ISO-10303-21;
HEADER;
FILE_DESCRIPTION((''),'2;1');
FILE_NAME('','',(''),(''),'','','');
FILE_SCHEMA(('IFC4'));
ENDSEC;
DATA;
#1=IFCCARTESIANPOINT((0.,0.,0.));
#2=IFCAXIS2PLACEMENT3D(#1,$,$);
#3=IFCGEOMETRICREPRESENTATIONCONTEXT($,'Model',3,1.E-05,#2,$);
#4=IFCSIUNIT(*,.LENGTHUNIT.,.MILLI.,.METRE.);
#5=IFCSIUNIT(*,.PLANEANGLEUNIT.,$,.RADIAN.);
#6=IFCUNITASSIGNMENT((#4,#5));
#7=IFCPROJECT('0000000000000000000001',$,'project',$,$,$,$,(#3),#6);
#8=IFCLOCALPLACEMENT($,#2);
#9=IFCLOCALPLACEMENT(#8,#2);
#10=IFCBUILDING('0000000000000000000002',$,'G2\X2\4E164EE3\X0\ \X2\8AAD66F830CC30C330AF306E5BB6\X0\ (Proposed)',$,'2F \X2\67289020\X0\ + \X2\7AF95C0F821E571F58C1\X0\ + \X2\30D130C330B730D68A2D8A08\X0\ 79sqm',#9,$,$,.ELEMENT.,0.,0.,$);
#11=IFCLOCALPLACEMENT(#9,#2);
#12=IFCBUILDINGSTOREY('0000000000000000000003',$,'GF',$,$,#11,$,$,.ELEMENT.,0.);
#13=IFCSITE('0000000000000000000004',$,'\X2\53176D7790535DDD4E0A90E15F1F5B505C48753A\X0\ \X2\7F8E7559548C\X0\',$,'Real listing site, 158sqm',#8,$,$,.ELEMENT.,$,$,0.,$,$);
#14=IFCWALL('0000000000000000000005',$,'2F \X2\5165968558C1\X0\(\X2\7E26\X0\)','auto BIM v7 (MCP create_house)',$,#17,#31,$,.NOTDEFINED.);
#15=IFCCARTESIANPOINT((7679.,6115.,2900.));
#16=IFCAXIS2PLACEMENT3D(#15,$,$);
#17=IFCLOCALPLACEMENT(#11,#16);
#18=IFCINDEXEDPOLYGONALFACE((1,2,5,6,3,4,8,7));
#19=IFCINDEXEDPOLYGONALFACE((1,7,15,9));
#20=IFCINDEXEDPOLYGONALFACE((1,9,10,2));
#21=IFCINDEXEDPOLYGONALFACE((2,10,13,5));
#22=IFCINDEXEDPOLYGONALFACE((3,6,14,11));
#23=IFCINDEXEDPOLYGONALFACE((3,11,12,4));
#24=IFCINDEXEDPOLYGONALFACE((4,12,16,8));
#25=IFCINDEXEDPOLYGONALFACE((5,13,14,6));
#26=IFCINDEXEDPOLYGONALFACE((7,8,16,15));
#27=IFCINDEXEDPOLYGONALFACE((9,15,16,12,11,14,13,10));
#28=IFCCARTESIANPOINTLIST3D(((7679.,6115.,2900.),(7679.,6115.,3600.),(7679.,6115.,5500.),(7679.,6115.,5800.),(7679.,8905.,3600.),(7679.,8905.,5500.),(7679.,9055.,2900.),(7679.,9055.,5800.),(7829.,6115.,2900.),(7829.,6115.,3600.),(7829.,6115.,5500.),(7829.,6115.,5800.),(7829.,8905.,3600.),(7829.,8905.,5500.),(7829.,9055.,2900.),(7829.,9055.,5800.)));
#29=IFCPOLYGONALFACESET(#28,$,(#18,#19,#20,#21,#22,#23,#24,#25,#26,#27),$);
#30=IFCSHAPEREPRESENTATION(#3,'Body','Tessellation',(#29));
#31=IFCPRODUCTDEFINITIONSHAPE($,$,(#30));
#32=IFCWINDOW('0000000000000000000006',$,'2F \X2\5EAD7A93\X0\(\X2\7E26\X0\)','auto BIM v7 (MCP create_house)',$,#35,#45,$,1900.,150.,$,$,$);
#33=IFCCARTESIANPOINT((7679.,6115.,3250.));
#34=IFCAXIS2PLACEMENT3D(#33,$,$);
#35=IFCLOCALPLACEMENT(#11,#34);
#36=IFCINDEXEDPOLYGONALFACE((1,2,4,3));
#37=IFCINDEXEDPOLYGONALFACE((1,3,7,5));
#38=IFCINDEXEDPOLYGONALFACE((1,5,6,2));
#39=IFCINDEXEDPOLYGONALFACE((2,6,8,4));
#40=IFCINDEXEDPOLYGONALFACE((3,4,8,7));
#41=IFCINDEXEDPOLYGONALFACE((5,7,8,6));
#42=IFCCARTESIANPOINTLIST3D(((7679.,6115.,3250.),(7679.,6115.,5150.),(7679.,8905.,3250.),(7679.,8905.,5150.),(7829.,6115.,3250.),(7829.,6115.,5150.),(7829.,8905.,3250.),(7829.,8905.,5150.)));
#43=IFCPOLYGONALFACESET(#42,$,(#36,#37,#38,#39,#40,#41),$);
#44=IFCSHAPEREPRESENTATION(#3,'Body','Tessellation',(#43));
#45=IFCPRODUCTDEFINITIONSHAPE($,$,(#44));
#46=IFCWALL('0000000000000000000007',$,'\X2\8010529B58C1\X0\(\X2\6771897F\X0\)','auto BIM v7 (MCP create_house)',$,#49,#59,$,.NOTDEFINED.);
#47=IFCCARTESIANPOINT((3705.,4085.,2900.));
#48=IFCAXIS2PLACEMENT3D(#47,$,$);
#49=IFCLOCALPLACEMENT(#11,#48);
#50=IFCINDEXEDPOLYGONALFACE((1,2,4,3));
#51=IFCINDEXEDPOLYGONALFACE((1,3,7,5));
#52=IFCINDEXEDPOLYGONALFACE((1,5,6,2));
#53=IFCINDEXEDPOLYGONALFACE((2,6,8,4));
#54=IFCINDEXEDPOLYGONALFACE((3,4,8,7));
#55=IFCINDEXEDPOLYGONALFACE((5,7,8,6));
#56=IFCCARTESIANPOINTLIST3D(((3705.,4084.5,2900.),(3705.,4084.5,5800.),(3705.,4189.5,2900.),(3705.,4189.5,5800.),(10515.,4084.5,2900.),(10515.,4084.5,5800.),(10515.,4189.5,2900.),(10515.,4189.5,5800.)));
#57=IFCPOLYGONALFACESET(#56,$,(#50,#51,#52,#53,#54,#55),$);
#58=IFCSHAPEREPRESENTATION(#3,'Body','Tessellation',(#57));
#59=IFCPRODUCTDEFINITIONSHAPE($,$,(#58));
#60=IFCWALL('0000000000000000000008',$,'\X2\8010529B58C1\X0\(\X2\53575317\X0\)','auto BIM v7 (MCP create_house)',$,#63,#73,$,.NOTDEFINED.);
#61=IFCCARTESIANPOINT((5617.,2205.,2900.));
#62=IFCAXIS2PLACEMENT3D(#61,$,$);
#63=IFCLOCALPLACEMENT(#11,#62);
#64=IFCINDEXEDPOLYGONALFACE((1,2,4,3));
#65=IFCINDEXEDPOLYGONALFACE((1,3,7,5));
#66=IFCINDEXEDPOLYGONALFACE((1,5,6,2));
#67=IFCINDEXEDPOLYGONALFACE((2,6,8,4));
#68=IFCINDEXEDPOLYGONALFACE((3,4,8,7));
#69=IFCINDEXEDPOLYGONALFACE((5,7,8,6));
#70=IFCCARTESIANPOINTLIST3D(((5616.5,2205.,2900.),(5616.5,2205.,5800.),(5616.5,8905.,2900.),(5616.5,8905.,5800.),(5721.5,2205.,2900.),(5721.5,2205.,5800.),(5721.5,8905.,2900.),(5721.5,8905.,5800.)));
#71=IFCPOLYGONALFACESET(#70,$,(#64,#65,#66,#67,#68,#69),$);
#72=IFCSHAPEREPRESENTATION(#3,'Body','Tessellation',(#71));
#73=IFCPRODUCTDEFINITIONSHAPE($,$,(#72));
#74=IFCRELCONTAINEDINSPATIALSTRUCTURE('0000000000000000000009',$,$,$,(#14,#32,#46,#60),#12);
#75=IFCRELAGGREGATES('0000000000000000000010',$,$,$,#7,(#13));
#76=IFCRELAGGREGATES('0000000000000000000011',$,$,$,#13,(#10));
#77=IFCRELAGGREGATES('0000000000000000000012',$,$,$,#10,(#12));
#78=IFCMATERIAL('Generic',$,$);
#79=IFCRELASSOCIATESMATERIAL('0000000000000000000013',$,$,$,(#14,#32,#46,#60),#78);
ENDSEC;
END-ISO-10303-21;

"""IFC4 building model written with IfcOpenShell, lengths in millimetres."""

from ifc_helpers import new_model, si_unit, frame, frame_2d, origin, place, context, project, spatial, rectangle, extrude, material, element, fill, save


model = new_model("IFC4")

# Units and contexts
model_context = context("Model", 3, precision=1e-05, world=origin())
ifc_project = project(units=[si_unit("LENGTHUNIT", "METRE", prefix="MILLI"), si_unit("PLANEANGLEUNIT", "RADIAN")], contexts=[model_context])

# Site, building, storey
site_placement = place(None, origin())
site = spatial("IfcSite", under=ifc_project, at=site_placement, Name="北海道川上郡弟子屈町 美留和", ObjectType="Real listing site, 158sqm", CompositionType="ELEMENT", RefElevation=0.0)
building_placement = place(site_placement, origin())
building = spatial("IfcBuilding", under=site, at=building_placement, Name="G2世代 読書ヌックの家 (Proposed)", ObjectType="2F 木造 + 竹小舞土壁 + パッシブ設計 79sqm", CompositionType="ELEMENT", ElevationOfRefHeight=0.0, ElevationOfTerrain=0.0)
storey_placement = place(building_placement, origin())
storey = spatial("IfcBuildingStorey", under=building, at=storey_placement, Name="GF", CompositionType="ELEMENT", Elevation=0.0)

# Shared definitions
ifc_material = material(Name="Generic")

# Wall, opening, window
wall_1_placement = place(storey_placement, frame((7679.0, 6115.0, 2900.0)))
wall_1 = element("IfcWall", 1, at=wall_1_placement, inside=storey, material=ifc_material, Name="2F 入隅壁(縦)", Description="auto BIM v7 (MCP create_house)", PredefinedType="NOTDEFINED", context=model_context, shape_type="SweptSolid", body=[
    extrude(rectangle(XDim=150.0, YDim=2940.0, at=frame_2d((75.0, 1470.0))), frame((7679.0, 6115.0, 2900.0)), (0.0, 0.0, 1.0), 2900.0),
])
opening_1_placement = place(storey_placement, frame((7679.0, 6115.0, 3250.0)))
opening_1 = element("IfcOpeningElement", 2, at=opening_1_placement, cuts=wall_1, PredefinedType="NOTDEFINED", context=model_context, shape_type="SweptSolid", body=[
    extrude(rectangle(XDim=150.0, YDim=2790.0, at=frame_2d((75.0, 1395.0))), frame((7679.0, 6115.0, 3250.0)), (0.0, 0.0, 1.0), 1900.0),
])
window_1_placement = place(storey_placement, frame((7679.0, 6115.0, 3250.0)))
window_1 = element("IfcWindow", 3, at=window_1_placement, inside=storey, material=ifc_material, Name="2F 庭窓(縦)", Description="auto BIM v7 (MCP create_house)", OverallHeight=1900.0, OverallWidth=150.0, context=model_context, shape_type="SweptSolid", body=[
    extrude(rectangle(XDim=150.0, YDim=2790.0, at=frame_2d((75.0, 1395.0))), frame((7679.0, 6115.0, 3250.0)), (0.0, 0.0, 1.0), 1900.0),
])
fill(opening_1, window_1)

# Walls
wall_2_placement = place(storey_placement, frame((3705.0, 4085.0, 2900.0)))
element("IfcWall", 4, at=wall_2_placement, inside=storey, material=ifc_material, Name="耐力壁(東西)", Description="auto BIM v7 (MCP create_house)", PredefinedType="NOTDEFINED", context=model_context, shape_type="SweptSolid", body=[
    extrude(rectangle(XDim=6810.0, YDim=105.0, at=frame_2d((3405.0, 52.0))), frame((3705.0, 4085.0, 2900.0)), (0.0, 0.0, 1.0), 2900.0),
])
wall_3_placement = place(storey_placement, frame((5617.0, 2205.0, 2900.0)))
element("IfcWall", 5, at=wall_3_placement, inside=storey, material=ifc_material, Name="耐力壁(南北)", Description="auto BIM v7 (MCP create_house)", PredefinedType="NOTDEFINED", context=model_context, shape_type="SweptSolid", body=[
    extrude(rectangle(XDim=105.0, YDim=6700.0, at=frame_2d((52.0, 3350.0))), frame((5617.0, 2205.0, 2900.0)), (0.0, 0.0, 1.0), 2900.0),
])

save(model, "model.ifc")
